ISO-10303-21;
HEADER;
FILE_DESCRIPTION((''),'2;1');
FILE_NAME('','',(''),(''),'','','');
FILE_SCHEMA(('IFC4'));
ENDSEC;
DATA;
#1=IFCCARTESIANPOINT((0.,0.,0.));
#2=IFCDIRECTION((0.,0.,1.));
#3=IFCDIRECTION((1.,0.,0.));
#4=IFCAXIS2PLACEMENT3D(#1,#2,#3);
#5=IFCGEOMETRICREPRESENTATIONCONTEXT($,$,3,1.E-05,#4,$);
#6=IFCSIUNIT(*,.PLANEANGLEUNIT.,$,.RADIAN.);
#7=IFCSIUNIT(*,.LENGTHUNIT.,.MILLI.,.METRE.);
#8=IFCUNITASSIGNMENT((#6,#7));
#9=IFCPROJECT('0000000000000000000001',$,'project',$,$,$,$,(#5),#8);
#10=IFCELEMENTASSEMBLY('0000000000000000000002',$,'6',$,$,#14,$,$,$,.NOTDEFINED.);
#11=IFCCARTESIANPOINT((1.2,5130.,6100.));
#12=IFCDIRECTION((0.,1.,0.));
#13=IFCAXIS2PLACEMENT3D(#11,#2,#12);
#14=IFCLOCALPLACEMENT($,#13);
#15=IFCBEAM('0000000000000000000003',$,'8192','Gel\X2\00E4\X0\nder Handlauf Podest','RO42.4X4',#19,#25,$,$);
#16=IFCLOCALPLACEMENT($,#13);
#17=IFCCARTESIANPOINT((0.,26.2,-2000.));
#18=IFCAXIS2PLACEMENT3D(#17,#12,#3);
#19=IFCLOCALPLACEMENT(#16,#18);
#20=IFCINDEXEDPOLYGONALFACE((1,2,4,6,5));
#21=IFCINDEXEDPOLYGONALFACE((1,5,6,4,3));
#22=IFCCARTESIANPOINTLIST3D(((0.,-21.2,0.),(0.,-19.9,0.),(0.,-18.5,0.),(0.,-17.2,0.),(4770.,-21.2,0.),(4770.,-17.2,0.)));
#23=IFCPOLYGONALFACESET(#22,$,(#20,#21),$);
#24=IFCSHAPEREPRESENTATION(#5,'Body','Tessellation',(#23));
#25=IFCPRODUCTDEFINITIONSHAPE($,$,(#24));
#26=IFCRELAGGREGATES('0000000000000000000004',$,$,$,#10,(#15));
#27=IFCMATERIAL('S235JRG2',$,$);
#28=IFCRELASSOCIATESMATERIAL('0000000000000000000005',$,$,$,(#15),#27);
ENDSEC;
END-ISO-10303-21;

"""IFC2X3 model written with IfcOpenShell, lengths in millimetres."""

from ifc_helpers import new_model, si_unit, frame, origin_with_axes, place, context, project, polyline, outline, extrude, material, element, aggregate, save


model = new_model("IFC2X3")

# Units and contexts
context_of_model = context(None, 3, precision=1e-05, world=origin_with_axes())
ifc_project = project(units=[si_unit("PLANEANGLEUNIT", "RADIAN"), si_unit("LENGTHUNIT", "METRE", prefix="MILLI")], contexts=[context_of_model])

# Element assembly, beam
assembly_placement = place(None, frame((1.2, 5130.0, 6100.0), z_axis=(0.0, 0.0, 1.0), x_axis=(0.0, 1.0, 0.0)))
assembly = element("IfcElementAssembly", 1, at=assembly_placement, Name="6", PredefinedType="NOTDEFINED")
ifc_material = material(Name="S235JRG2")
placement_1 = place(None, frame((1.2, 5130.0, 6100.0), z_axis=(0.0, 0.0, 1.0), x_axis=(0.0, 1.0, 0.0)))
beam_1_placement = place(placement_1, frame((0.0, 26.2, -2000.0), z_axis=(0.0, 1.0, 0.0), x_axis=(1.0, 0.0, 0.0)))
beam_1 = element("IfcBeam", 2, at=beam_1_placement, material=ifc_material, Name="8192", Description="Geländer Handlauf Podest", ObjectType="RO42.4X4", context=context_of_model, shape_type="SweptSolid", body=[
    extrude(outline(polyline([(-21.2, 0.0), (-21.2, 0.0), (-17.2, 0.0), (-17.2, 0.0), (-21.2, 0.0)])), frame((0.0, 0.0, 0.0), z_axis=(1.0, 0.0, 0.0), x_axis=(0.0, 1.0, 0.0)), (0.0, 0.0, 1.0), 4770.0),
])
aggregate(assembly, [beam_1])

save(model, "model.ifc")
